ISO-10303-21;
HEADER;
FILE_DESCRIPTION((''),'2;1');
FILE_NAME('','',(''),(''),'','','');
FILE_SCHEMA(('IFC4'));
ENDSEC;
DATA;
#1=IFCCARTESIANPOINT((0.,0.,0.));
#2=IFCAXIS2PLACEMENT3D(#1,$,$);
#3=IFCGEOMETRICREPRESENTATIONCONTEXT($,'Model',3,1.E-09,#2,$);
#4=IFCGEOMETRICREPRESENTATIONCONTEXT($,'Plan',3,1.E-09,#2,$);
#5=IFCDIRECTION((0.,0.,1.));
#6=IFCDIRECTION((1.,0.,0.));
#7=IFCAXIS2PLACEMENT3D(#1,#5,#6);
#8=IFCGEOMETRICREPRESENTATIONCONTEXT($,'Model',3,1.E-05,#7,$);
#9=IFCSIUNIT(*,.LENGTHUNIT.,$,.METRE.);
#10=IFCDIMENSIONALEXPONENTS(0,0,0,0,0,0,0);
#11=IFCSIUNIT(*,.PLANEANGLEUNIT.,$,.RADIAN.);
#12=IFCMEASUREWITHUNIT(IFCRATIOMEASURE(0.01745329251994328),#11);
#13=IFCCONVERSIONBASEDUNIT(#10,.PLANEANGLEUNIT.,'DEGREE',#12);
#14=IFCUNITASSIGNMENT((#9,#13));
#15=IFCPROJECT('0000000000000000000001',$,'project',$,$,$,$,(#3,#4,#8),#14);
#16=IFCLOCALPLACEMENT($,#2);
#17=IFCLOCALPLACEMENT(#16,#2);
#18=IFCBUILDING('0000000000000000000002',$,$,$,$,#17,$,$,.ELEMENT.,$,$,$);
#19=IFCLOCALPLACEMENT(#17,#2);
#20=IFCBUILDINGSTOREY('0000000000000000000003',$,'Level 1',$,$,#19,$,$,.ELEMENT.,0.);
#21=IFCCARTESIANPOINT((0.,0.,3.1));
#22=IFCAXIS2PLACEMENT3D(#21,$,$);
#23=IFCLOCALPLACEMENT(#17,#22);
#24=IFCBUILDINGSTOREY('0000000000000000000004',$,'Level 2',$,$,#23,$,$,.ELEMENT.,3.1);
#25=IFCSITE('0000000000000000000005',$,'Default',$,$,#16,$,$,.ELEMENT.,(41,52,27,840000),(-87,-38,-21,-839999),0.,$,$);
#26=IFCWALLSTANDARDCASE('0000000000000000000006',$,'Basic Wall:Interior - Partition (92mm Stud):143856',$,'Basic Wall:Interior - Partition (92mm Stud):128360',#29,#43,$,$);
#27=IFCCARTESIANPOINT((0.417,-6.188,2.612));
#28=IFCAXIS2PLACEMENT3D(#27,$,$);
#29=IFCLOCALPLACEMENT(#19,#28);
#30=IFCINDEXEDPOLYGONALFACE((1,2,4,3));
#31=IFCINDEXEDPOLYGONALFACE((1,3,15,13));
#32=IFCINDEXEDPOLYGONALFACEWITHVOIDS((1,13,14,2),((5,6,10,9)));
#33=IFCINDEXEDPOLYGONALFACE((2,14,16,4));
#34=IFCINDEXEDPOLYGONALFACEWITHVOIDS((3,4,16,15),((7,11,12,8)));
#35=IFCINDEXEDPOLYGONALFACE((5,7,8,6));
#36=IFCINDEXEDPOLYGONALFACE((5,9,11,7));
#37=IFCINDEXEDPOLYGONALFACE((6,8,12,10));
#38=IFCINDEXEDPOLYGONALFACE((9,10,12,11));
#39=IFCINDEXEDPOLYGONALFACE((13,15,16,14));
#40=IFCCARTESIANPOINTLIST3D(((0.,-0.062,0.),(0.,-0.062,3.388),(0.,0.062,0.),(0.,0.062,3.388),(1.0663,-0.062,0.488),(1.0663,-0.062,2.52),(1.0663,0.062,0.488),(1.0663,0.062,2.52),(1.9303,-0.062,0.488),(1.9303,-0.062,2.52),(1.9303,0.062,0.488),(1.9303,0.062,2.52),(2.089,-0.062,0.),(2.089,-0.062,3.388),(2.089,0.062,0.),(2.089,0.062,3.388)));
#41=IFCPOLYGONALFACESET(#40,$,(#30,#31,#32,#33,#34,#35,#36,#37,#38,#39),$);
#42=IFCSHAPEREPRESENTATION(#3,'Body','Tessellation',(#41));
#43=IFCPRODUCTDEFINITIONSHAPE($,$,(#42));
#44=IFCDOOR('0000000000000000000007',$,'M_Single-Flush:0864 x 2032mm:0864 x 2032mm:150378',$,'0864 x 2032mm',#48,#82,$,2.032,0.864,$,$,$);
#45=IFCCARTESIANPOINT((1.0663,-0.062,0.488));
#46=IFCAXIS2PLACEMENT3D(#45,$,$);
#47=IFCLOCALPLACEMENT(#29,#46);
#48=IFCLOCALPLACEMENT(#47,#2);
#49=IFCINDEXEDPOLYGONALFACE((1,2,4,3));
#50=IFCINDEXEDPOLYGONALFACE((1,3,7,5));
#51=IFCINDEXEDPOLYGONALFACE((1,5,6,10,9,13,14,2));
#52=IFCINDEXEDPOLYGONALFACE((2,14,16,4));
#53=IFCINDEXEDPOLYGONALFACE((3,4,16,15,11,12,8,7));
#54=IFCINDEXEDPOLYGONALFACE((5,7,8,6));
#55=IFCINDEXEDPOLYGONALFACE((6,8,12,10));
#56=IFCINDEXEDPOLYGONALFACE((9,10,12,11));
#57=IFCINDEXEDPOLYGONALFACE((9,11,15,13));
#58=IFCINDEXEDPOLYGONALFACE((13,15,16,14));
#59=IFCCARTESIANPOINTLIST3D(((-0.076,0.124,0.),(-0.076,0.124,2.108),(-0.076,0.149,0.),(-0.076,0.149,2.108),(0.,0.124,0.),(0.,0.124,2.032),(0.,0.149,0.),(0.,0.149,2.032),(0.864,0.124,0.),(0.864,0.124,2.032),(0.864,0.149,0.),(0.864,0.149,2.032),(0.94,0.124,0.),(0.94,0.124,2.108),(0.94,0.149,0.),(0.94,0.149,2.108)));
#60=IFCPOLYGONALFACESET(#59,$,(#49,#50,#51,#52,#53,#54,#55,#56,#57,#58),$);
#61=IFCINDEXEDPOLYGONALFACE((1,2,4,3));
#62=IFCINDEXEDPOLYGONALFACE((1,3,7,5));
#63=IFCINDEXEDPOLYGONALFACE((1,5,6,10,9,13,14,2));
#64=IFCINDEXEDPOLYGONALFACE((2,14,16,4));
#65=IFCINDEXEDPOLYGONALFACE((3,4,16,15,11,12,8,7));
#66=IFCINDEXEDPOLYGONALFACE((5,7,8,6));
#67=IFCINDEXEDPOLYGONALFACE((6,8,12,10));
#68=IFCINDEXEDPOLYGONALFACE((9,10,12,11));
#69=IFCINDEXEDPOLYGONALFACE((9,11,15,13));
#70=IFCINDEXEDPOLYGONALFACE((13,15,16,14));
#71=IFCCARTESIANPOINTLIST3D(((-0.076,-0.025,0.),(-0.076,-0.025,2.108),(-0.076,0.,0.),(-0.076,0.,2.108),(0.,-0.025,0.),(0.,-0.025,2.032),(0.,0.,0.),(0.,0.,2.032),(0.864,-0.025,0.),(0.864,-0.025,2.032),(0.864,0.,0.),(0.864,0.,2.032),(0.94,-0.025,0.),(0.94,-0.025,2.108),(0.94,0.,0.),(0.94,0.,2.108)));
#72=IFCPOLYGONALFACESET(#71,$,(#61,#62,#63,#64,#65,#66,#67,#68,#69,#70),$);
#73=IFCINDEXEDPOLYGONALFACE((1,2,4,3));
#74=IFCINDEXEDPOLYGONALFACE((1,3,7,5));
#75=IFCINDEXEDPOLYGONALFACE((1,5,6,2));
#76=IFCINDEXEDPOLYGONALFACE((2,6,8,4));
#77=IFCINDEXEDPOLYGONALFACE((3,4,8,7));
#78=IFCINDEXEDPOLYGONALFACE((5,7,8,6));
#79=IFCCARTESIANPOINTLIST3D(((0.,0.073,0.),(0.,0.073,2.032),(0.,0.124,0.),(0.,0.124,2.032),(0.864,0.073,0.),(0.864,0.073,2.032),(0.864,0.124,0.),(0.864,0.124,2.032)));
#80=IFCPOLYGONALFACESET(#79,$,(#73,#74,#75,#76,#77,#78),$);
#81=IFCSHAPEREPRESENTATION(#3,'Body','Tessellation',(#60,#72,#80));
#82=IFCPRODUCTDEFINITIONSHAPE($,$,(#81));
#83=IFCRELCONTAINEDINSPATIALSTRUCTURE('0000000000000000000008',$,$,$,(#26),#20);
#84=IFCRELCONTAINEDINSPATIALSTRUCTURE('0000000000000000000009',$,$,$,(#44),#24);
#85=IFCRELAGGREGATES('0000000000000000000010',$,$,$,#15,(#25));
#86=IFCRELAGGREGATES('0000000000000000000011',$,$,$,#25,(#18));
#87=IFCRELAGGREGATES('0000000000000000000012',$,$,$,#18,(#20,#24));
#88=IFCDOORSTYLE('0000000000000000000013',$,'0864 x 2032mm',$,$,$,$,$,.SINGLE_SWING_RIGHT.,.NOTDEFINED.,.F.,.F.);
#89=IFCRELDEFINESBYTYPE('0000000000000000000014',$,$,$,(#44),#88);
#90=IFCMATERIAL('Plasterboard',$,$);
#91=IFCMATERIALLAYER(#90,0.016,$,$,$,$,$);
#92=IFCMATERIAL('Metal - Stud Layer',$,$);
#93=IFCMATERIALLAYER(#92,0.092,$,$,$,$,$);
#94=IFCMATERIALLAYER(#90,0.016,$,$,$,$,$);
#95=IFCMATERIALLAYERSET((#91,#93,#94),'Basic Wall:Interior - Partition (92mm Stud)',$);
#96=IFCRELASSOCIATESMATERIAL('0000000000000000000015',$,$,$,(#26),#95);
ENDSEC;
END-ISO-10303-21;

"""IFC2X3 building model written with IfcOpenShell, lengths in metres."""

from ifc_helpers import new_model, entity, si_unit, converted_unit, frame, frame_2d, origin, origin_with_axes, origin_2d_with_axis, place, context, project, spatial, polyline, rectangle, outline, extrude, source, transform, mapped, material, layer, layer_set, layer_usage, type_object, type_shapes, element, fill, save


model = new_model("IFC2X3")

# Units and contexts
model_context_1 = context("Model", 3, precision=1e-09, world=origin())
plan_context = context("Plan", 3, precision=1e-09, world=origin())
model_context_2 = context("Model", 3, precision=1e-05, world=origin_with_axes())
ifc_project = project(units=[si_unit("LENGTHUNIT", "METRE"), converted_unit("PLANEANGLEUNIT", "DEGREE", entity("IfcRatioMeasure", 0.01745329251994328), si_unit("PLANEANGLEUNIT", "RADIAN"), dimensions=[0, 0, 0, 0, 0, 0, 0])], contexts=[model_context_1, plan_context, model_context_2])

# Site, building, storey
site_placement = place(None, origin())
site = spatial("IfcSite", under=ifc_project, at=site_placement, Name="Default", CompositionType="ELEMENT", RefLatitude=(41, 52, 27, 840000), RefLongitude=(-87, -38, -21, -839999), RefElevation=0.0)
building_placement = place(site_placement, origin())
building = spatial("IfcBuilding", under=site, at=building_placement, CompositionType="ELEMENT")
storey_1_placement = place(building_placement, origin())
storey_1 = spatial("IfcBuildingStorey", under=building, at=storey_1_placement, Name="Level 1", CompositionType="ELEMENT", Elevation=0.0)

# Wall, opening
ifc_material_1 = material(Name="Plasterboard")
ifc_layer_1 = layer(ifc_material_1, 0.016)
ifc_material_2 = material(Name="Metal - Stud Layer")
ifc_layer_2 = layer(ifc_material_2, 0.092)
ifc_layer_3 = layer(ifc_material_1, 0.016)
ifc_layer_set = layer_set([ifc_layer_1, ifc_layer_2, ifc_layer_3], Name="Basic Wall:Interior - Partition (92mm Stud)")
ifc_layer_usage = layer_usage(ifc_layer_set, "AXIS2", "NEGATIVE", 0.062)
wall_placement = place(storey_1_placement, frame((0.417, -6.188, 2.612)))
wall = element("IfcWallStandardCase", 1, at=wall_placement, inside=storey_1, material=ifc_layer_usage, Name="Basic Wall:Interior - Partition (92mm Stud):143856", ObjectType="Basic Wall:Interior - Partition (92mm Stud):128360", context=model_context_1, shape_type="SweptSolid", body=[
    extrude(rectangle(XDim=2.089, YDim=0.124, at=frame_2d((1.0445, 0.0), x_axis=(-1.0, 0.0))), origin(), (0.0, 0.0, 1.0), 3.388),
])
opening_placement = place(wall_placement, frame((1.0663, -0.062, 0.488)))
opening = element("IfcOpeningElement", 2, at=opening_placement, cuts=wall, ObjectType="Opening", context=model_context_1, shape_type="SweptSolid", body=[
    extrude(rectangle(XDim=0.864, YDim=2.032, at=frame_2d((1.016, 0.432), x_axis=(0.0, 1.0))), frame((0.0, 0.0, 0.0), z_axis=(0.0, 1.0, 0.0), x_axis=(0.0, 0.0, 1.0)), (0.0, 0.0, 1.0), 0.124),
])

# Shared definitions
storey_2_placement = place(building_placement, frame((0.0, 0.0, 3.1)))
storey_2 = spatial("IfcBuildingStorey", under=building, at=storey_2_placement, Name="Level 2", CompositionType="ELEMENT", Elevation=3.1)

# Door
door_style = type_object("IfcDoorStyle", Name="0864 x 2032mm", ConstructionType="NOTDEFINED", OperationType="SINGLE_SWING_RIGHT", ParameterTakesPrecedence=False, Sizeable=False)
shared_shape = source(origin(), model_context_1, "Body", "SweptSolid", [
    extrude(outline(polyline([(-0.508, -1.073), (0.508, -1.073), (0.508, 1.035), (0.432, 1.035), (0.432, -0.997), (-0.432, -0.997), (-0.432, 1.035), (-0.508, 1.035), (-0.508, -1.073)])), frame((0.432, 0.124, 1.035), z_axis=(0.0, 1.0, 0.0), x_axis=(1.0, 0.0, 0.0)), (0.0, 0.0, 1.0), 0.025),
    extrude(outline(polyline([(-1.073, -0.508), (1.035, -0.508), (1.035, -0.432), (-0.997, -0.432), (-0.997, 0.432), (1.035, 0.432), (1.035, 0.508), (-1.073, 0.508), (-1.073, -0.508)])), frame((0.432, -0.025, 1.035), z_axis=(0.0, 1.0, 0.0), x_axis=(0.0, 0.0, -1.0)), (0.0, 0.0, 1.0), 0.025),
    extrude(rectangle(XDim=0.051, YDim=0.864, at=origin_2d_with_axis()), frame((0.432, 0.0985, 0.0), z_axis=(0.0, 0.0, 1.0), x_axis=(0.0, 1.0, 0.0)), (0.0, 0.0, 1.0), 2.032),
])
type_shapes(door_style, [shared_shape])
door_placement = place(opening_placement, origin())
door = element("IfcDoor", 3, at=door_placement, inside=storey_2, type_object=door_style, Name="M_Single-Flush:0864 x 2032mm:0864 x 2032mm:150378", ObjectType="0864 x 2032mm", OverallHeight=2.032, OverallWidth=0.864, context=model_context_1, shape_type="MappedRepresentation", body=[
    mapped(shared_shape, transform((0.0, 0.0, 0.0), scale=1.0)),
])
fill(opening, door)

save(model, "model.ifc")
